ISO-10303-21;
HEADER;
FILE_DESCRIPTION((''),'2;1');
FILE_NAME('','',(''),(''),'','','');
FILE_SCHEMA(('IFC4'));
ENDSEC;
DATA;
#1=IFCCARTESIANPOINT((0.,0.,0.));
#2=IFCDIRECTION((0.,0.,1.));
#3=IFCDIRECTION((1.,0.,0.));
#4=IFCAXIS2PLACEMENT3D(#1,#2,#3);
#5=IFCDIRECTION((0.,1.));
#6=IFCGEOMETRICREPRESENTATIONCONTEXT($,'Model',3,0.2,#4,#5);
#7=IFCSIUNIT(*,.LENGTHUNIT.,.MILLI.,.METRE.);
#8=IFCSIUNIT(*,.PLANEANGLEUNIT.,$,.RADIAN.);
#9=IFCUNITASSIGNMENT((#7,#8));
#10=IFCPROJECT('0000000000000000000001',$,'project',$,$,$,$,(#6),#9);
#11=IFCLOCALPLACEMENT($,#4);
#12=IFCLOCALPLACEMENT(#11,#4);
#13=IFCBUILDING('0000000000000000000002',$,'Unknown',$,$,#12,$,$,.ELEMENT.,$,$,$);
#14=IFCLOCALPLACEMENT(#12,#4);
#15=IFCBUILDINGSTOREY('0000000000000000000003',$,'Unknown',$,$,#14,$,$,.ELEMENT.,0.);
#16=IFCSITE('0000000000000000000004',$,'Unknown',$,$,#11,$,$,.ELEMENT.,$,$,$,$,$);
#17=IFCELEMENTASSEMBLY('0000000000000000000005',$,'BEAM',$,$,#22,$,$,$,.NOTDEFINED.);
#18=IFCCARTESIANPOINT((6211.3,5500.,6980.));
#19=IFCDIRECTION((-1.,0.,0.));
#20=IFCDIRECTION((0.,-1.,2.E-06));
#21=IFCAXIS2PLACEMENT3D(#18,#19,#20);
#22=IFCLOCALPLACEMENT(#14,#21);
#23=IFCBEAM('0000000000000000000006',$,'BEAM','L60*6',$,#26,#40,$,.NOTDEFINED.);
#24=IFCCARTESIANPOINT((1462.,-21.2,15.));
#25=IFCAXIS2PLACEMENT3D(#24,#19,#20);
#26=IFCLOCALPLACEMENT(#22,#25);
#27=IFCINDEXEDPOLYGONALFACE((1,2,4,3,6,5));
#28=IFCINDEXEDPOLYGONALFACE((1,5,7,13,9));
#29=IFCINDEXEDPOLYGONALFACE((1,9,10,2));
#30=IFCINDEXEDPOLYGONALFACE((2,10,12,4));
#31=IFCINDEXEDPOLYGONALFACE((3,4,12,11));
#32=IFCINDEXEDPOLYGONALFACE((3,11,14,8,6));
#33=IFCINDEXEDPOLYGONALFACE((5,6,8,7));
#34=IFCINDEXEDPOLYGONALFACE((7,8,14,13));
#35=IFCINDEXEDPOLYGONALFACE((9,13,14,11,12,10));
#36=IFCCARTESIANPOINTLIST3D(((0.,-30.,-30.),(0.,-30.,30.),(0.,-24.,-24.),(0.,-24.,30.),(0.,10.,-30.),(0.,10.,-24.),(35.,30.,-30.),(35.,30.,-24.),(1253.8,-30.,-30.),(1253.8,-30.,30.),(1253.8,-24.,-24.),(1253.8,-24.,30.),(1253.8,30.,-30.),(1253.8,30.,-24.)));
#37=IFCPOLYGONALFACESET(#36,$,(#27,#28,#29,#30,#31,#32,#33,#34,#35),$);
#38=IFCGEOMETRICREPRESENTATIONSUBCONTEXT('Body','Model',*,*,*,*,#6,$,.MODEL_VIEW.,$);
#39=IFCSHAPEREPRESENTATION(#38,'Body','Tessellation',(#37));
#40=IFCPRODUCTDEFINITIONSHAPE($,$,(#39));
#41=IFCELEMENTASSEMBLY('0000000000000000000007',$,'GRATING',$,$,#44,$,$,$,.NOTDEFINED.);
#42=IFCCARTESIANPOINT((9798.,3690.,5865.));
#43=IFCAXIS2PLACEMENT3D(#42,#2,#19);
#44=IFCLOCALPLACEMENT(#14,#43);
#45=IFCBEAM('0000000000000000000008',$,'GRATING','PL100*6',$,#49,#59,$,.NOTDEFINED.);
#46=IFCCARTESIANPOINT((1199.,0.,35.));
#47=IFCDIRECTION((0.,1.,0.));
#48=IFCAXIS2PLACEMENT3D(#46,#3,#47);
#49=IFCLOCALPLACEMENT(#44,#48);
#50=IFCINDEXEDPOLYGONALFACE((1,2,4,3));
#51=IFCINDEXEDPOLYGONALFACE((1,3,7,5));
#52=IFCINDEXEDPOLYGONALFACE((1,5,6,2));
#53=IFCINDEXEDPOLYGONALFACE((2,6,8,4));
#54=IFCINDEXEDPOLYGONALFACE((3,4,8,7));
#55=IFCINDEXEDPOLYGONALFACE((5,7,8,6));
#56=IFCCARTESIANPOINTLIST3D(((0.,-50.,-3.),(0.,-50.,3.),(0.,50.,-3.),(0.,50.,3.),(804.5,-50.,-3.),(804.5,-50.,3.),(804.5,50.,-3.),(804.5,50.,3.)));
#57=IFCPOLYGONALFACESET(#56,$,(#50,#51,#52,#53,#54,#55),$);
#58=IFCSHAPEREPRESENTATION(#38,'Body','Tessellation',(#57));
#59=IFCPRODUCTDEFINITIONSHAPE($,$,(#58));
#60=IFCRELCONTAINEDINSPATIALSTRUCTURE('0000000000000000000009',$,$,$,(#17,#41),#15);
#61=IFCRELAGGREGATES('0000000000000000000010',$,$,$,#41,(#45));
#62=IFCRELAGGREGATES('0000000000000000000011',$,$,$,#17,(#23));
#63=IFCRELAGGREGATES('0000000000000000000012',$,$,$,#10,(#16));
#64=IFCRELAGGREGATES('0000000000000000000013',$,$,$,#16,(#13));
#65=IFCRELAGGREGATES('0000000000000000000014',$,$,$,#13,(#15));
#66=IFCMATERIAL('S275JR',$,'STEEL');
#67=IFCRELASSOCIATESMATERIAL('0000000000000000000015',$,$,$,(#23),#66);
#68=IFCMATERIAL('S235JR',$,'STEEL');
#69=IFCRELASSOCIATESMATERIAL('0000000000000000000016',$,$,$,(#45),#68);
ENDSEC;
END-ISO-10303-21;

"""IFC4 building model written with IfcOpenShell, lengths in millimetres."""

from ifc_helpers import new_model, si_unit, direction, frame, origin_with_axes, place, context, subcontext, project, spatial, line, indexed_curve, outline, extrude, material, element, aggregate, save


model = new_model("IFC4")

# Units and contexts
model_context = context("Model", 3, precision=0.2, world=origin_with_axes(), true_north=direction((0.0, 1.0)))
body_context = subcontext(model_context, "Body", "Model", "MODEL_VIEW")
ifc_project = project(units=[si_unit("LENGTHUNIT", "METRE", prefix="MILLI"), si_unit("PLANEANGLEUNIT", "RADIAN")], contexts=[model_context])

# Site, building, storey
site_placement = place(None, origin_with_axes())
site = spatial("IfcSite", under=ifc_project, at=site_placement, Name="Unknown", CompositionType="ELEMENT")
building_placement = place(site_placement, origin_with_axes())
building = spatial("IfcBuilding", under=site, at=building_placement, Name="Unknown", CompositionType="ELEMENT")
storey_placement = place(building_placement, origin_with_axes())
storey = spatial("IfcBuildingStorey", under=building, at=storey_placement, Name="Unknown", CompositionType="ELEMENT", Elevation=0.0)

# Shared definitions
ifc_material_1 = material(Name="S275JR", Category="STEEL")

# Element assembly, beam, voiding feature
assembly_1_placement = place(storey_placement, frame((6211.3, 5500.0, 6980.0), z_axis=(-1.0, 0.0, 0.0), x_axis=(0.0, -1.0, 0.000002)))
assembly_1 = element("IfcElementAssembly", 1, at=assembly_1_placement, inside=storey, Name="BEAM", PredefinedType="NOTDEFINED")
beam_1_placement = place(assembly_1_placement, frame((1462.0, -21.2, 15.0), z_axis=(-1.0, 0.0, 0.0), x_axis=(0.0, -1.0, 0.000002)))
beam_1 = element("IfcBeam", 2, at=beam_1_placement, material=ifc_material_1, Name="BEAM", Description="L60*6", PredefinedType="NOTDEFINED", context=body_context, shape_type="SolidModel", body=[
    extrude(outline(indexed_curve([(-30.0, -30.0), (30.0, -30.0), (30.0, -24.0), (-24.0, -24.0), (-24.0, 30.0), (-30.0, 30.0)], segments=[line(1, 2, 3, 4, 5, 6, 1)])), frame((0.0, 0.0, 0.0), z_axis=(-1.0, 0.0, 0.0), x_axis=(0.0, 0.0, 1.0)), (0.0, -0.000002, -1.0), 1253.8),
])
voiding_feature_placement = place(beam_1_placement, frame((0.0, 10.0, 0.0), z_axis=(0.0, -0.000002, -1.0), x_axis=(0.0, 1.0, 0.0)))
element("IfcVoidingFeature", 3, at=voiding_feature_placement, cuts=beam_1, Name="CUTPART", PredefinedType="HOLE", context=body_context, shape_type="SolidModel", body=[
    extrude(outline(indexed_curve([(0.0, 0.0), (20.0, 0.0), (20.0, 35.0)], segments=[line(1, 2, 3, 1)])), frame((0.0, 0.0, 33.0), z_axis=(0.0, 0.0, 1.0), x_axis=(1.0, 0.0, 0.0)), (0.0, -0.000002, -1.0), 66.0),
])

# Element assembly, beam
ifc_material_2 = material(Name="S235JR", Category="STEEL")
assembly_2_placement = place(storey_placement, frame((9798.0, 3690.0, 5865.0), z_axis=(0.0, 0.0, 1.0), x_axis=(-1.0, 0.0, 0.0)))
assembly_2 = element("IfcElementAssembly", 4, at=assembly_2_placement, inside=storey, Name="GRATING", PredefinedType="NOTDEFINED")
beam_2_placement = place(assembly_2_placement, frame((1199.0, 0.0, 35.0), z_axis=(1.0, 0.0, 0.0), x_axis=(0.0, 1.0, 0.0)))
beam_2 = element("IfcBeam", 5, at=beam_2_placement, material=ifc_material_2, Name="GRATING", Description="PL100*6", PredefinedType="NOTDEFINED", context=body_context, shape_type="SolidModel", body=[
    extrude(outline(indexed_curve([(-3.0, -50.0), (3.0, -50.0), (3.0, 50.0), (-3.0, 50.0)], segments=[line(1, 2, 3, 4, 1)])), frame((0.0, 0.0, 0.0), z_axis=(-1.0, 0.0, 0.0), x_axis=(0.0, 0.0, 1.0)), (0.0, -0.000002, -1.0), 804.5),
])
aggregate(assembly_2, [beam_2])

aggregate(assembly_1, [beam_1])

save(model, "model.ifc")
